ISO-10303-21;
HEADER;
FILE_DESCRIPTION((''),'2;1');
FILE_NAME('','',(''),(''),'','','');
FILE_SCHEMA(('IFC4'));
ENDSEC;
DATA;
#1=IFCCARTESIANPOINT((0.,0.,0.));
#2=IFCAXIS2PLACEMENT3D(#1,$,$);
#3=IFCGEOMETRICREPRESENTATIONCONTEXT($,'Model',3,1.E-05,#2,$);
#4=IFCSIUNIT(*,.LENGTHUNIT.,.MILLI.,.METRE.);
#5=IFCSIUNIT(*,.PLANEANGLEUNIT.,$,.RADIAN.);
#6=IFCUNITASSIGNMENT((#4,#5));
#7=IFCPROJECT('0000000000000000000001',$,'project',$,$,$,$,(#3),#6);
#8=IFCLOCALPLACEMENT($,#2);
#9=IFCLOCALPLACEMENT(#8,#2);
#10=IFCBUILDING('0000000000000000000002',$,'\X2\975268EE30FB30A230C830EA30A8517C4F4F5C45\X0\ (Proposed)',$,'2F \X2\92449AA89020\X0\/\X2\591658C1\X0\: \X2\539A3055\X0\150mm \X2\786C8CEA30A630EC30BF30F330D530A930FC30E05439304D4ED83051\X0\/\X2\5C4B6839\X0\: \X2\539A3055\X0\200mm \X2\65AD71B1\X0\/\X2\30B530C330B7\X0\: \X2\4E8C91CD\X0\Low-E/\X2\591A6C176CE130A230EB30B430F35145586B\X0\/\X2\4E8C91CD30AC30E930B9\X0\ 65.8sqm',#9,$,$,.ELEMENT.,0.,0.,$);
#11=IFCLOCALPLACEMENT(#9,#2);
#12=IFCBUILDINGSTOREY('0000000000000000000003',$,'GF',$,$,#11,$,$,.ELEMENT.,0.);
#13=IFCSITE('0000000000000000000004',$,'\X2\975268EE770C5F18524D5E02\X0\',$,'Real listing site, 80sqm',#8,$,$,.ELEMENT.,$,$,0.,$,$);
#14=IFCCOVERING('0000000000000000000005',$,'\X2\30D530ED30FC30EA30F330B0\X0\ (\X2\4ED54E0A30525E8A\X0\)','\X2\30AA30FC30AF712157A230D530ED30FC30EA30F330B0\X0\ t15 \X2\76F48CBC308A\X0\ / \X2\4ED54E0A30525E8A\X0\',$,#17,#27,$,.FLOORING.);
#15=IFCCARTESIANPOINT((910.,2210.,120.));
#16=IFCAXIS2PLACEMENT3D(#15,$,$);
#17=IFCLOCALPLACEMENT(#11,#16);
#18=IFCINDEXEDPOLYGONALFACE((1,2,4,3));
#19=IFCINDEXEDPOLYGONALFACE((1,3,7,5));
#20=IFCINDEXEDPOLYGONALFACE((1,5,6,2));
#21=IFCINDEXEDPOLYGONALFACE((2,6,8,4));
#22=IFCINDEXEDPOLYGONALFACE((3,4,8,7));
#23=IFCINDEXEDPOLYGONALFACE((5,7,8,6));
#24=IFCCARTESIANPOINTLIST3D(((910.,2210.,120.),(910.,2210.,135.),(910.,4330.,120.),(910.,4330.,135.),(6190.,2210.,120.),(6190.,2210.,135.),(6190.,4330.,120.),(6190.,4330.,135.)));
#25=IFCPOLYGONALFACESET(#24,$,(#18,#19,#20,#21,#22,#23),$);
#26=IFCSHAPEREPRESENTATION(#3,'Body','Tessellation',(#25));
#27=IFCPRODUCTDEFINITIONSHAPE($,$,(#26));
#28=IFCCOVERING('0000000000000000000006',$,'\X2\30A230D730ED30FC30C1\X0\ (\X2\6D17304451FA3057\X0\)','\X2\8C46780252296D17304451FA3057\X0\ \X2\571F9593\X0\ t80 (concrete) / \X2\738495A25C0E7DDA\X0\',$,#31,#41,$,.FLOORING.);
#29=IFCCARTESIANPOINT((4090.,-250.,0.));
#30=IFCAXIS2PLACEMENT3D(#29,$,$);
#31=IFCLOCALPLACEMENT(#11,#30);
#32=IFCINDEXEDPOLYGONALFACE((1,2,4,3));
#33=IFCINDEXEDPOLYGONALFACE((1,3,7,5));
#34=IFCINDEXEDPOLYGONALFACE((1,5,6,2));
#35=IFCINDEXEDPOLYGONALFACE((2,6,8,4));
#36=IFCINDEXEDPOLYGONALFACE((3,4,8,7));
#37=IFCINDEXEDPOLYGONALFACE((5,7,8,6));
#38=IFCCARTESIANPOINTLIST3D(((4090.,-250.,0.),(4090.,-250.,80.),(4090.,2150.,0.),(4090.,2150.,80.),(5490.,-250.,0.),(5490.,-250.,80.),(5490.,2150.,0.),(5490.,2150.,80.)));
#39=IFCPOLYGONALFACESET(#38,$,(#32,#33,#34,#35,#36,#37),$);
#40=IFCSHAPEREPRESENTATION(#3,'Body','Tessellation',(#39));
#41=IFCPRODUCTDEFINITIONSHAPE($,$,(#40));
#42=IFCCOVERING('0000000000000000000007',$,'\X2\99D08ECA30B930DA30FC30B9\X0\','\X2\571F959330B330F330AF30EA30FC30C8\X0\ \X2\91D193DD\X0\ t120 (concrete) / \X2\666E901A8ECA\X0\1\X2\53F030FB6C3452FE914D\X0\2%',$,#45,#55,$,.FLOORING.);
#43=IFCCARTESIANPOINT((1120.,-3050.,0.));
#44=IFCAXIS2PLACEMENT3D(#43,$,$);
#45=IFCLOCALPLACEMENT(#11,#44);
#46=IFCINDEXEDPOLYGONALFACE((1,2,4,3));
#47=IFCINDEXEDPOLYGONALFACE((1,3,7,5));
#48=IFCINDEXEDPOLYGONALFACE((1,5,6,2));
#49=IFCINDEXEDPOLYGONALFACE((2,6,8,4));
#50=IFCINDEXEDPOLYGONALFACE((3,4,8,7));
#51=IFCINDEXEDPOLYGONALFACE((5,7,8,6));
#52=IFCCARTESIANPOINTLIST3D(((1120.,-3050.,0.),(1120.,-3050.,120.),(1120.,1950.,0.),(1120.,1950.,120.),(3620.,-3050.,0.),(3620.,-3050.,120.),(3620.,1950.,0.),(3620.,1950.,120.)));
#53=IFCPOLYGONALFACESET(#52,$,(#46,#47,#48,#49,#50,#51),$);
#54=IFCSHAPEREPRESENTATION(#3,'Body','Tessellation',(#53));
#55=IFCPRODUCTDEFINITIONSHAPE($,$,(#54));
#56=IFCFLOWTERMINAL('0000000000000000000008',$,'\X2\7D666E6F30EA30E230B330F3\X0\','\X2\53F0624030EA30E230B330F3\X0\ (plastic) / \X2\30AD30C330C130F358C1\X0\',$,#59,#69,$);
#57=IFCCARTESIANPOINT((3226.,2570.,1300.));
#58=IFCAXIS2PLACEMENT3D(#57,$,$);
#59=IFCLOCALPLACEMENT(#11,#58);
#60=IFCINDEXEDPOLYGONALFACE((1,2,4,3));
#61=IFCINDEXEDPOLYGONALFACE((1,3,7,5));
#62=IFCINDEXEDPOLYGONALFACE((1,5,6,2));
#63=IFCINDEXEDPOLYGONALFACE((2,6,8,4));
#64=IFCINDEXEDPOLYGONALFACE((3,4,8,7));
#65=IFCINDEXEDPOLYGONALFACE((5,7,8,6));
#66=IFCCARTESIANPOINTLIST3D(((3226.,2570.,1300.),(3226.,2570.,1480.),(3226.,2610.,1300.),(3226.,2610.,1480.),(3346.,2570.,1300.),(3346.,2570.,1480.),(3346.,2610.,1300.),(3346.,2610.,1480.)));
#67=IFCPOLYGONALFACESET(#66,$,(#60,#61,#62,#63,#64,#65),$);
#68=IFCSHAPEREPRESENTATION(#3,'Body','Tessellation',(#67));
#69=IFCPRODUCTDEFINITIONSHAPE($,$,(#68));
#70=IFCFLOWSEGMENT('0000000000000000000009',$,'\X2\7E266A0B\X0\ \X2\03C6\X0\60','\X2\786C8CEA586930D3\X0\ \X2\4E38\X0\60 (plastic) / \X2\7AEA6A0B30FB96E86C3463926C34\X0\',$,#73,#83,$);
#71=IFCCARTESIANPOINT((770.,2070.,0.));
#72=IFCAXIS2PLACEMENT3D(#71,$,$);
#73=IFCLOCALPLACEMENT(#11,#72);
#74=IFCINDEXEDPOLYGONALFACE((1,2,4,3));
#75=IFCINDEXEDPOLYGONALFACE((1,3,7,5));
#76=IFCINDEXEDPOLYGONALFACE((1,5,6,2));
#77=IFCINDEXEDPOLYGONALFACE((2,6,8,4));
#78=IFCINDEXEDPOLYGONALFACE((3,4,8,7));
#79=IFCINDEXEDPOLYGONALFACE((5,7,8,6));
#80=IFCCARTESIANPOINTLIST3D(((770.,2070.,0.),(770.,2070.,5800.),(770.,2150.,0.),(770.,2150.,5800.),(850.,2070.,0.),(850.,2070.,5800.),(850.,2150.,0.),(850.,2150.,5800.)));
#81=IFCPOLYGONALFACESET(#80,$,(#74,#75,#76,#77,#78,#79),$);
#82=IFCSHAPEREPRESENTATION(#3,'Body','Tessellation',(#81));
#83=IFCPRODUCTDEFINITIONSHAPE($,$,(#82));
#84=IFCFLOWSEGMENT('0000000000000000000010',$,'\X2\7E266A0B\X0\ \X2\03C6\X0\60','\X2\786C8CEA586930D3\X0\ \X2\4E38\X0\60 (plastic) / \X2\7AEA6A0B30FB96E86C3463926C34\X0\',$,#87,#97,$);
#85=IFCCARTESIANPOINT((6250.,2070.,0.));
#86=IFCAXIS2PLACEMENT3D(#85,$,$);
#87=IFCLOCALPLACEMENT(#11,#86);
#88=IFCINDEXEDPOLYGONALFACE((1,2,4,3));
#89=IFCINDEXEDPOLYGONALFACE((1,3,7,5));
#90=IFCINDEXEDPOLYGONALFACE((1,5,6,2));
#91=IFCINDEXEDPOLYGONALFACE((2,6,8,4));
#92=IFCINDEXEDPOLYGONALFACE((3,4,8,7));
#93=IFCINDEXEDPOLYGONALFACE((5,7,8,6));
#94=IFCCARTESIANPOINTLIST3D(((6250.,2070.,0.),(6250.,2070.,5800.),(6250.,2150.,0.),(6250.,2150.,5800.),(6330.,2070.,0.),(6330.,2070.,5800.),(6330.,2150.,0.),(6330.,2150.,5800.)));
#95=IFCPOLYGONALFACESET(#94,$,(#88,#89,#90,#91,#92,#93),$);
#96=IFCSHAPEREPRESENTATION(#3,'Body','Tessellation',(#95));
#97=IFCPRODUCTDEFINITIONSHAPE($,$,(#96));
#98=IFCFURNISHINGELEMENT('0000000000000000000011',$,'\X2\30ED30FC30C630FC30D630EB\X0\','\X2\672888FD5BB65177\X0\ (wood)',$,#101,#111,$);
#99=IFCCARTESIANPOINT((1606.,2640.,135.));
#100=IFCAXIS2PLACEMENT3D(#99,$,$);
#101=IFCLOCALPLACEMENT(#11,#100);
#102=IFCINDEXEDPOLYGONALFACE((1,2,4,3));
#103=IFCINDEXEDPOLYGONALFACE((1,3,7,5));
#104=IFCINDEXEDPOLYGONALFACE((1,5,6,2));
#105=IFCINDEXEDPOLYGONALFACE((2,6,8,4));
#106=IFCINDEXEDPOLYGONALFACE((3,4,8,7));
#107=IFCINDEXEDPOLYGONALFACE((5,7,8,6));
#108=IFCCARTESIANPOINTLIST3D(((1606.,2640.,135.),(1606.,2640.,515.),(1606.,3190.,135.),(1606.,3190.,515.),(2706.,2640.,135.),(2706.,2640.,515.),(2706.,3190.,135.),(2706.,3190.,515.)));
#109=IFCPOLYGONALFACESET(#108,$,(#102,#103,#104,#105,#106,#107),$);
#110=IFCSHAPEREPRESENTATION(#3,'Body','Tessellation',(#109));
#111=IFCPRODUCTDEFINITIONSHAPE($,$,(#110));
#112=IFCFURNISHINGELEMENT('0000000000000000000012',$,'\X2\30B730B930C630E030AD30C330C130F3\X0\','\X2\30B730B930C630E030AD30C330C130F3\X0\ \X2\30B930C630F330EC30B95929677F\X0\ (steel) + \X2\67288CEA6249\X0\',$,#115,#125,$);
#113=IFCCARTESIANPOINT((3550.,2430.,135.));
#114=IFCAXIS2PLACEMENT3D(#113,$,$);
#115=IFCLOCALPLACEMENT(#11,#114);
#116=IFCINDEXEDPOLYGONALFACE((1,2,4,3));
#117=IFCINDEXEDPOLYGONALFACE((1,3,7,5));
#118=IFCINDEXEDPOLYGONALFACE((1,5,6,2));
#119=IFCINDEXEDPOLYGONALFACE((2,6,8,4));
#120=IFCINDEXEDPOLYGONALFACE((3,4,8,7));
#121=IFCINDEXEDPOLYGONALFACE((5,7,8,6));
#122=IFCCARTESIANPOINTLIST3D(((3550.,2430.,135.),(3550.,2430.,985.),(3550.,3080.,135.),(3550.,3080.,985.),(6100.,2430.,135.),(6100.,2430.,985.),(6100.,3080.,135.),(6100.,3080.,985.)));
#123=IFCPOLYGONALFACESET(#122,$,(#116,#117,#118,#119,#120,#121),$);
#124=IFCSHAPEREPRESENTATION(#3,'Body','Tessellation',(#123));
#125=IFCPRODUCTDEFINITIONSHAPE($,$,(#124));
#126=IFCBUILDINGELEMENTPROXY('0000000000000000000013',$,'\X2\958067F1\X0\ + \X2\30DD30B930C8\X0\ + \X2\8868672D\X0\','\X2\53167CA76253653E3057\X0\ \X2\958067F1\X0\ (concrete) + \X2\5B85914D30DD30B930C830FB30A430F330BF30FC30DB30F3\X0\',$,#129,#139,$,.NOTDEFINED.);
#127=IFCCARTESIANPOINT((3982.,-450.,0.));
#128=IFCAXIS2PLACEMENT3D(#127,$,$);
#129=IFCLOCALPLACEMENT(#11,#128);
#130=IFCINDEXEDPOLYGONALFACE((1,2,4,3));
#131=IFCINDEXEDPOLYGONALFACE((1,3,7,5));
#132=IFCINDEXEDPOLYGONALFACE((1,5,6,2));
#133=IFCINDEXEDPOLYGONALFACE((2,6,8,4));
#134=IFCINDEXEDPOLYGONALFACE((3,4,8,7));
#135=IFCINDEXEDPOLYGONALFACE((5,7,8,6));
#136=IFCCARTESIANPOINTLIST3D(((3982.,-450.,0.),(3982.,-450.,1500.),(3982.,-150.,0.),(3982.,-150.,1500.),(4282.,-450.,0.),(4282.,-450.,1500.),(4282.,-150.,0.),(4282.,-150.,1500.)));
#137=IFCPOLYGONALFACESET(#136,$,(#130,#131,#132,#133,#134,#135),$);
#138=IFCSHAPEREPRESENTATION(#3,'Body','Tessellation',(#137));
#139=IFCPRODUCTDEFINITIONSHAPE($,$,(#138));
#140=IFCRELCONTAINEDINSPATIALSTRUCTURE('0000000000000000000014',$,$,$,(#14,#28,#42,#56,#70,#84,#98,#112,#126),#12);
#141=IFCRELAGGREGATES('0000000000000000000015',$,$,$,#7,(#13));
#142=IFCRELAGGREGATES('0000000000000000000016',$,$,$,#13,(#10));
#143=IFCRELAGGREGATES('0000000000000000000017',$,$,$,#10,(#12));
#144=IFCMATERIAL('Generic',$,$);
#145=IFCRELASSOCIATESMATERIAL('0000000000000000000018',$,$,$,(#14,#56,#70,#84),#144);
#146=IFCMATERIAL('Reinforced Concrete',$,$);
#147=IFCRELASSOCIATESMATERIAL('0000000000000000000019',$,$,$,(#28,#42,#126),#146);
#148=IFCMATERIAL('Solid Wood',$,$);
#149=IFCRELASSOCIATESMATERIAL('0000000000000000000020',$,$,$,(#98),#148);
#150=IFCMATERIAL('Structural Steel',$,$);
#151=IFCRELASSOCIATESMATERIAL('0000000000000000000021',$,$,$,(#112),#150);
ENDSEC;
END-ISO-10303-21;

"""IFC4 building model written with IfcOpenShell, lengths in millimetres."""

from ifc_helpers import new_model, si_unit, frame, frame_2d, origin, place, context, project, spatial, rectangle, extrude, material, element, save


model = new_model("IFC4")

# Units and contexts
model_context = context("Model", 3, precision=1e-05, world=origin())
ifc_project = project(units=[si_unit("LENGTHUNIT", "METRE", prefix="MILLI"), si_unit("PLANEANGLEUNIT", "RADIAN")], contexts=[model_context])

# Site, building, storey
site_placement = place(None, origin())
site = spatial("IfcSite", under=ifc_project, at=site_placement, Name="青森県弘前市", ObjectType="Real listing site, 80sqm", CompositionType="ELEMENT", RefElevation=0.0)
building_placement = place(site_placement, origin())
building = spatial("IfcBuilding", under=site, at=building_placement, Name="青森・アトリエ兼住居 (Proposed)", ObjectType="2F 鉄骨造/外壁: 厚さ150mm 硬質ウレタンフォーム吹き付け/屋根: 厚さ200mm 断熱/サッシ: 二重Low-E/多気泡アルゴン充填/二重ガラス 65.8sqm", CompositionType="ELEMENT", ElevationOfRefHeight=0.0, ElevationOfTerrain=0.0)
storey_placement = place(building_placement, origin())
storey = spatial("IfcBuildingStorey", under=building, at=storey_placement, Name="GF", CompositionType="ELEMENT", Elevation=0.0)

# Shared definitions
ifc_material_1 = material(Name="Solid Wood")

# Shared definitions
ifc_material_2 = material(Name="Reinforced Concrete")

# Coverings
ifc_material_3 = material(Name="Generic")
covering_1_placement = place(storey_placement, frame((910.0, 2210.0, 120.0)))
element("IfcCovering", 1, at=covering_1_placement, inside=storey, material=ifc_material_3, Name="フローリング (仕上げ床)", Description="オーク無垢フローリング t15 直貼り / 仕上げ床", PredefinedType="FLOORING", context=model_context, shape_type="SweptSolid", body=[
    extrude(rectangle(XDim=5280.0, YDim=2120.0, at=frame_2d((2640.0, 1060.0))), frame((910.0, 2210.0, 120.0)), (0.0, 0.0, 1.0), 15.0),
])
covering_2_placement = place(storey_placement, frame((4090.0, -250.0, 0.0)))
element("IfcCovering", 2, at=covering_2_placement, inside=storey, material=ifc_material_2, Name="アプローチ (洗い出し)", Description="豆砂利洗い出し 土間 t80 (concrete) / 玄関導線", PredefinedType="FLOORING", context=model_context, shape_type="SweptSolid", body=[
    extrude(rectangle(XDim=1400.0, YDim=2400.0, at=frame_2d((700.0, 1200.0))), frame((4090.0, -250.0, 0.0)), (0.0, 0.0, 1.0), 80.0),
])
covering_3_placement = place(storey_placement, frame((1120.0, -3050.0, 0.0)))
element("IfcCovering", 3, at=covering_3_placement, inside=storey, material=ifc_material_2, Name="駐車スペース", Description="土間コンクリート 金鏝 t120 (concrete) / 普通車1台・水勾配2%", PredefinedType="FLOORING", context=model_context, shape_type="SweptSolid", body=[
    extrude(rectangle(XDim=2500.0, YDim=5000.0, at=frame_2d((1250.0, 2500.0))), frame((1120.0, -3050.0, 0.0)), (0.0, 0.0, 1.0), 120.0),
])

# Flow terminal
flow_terminal_placement = place(storey_placement, frame((3226.0, 2570.0, 1300.0)))
element("IfcFlowTerminal", 4, at=flow_terminal_placement, inside=storey, material=ifc_material_3, Name="給湯リモコン", Description="台所リモコン (plastic) / キッチン壁", context=model_context, shape_type="SweptSolid", body=[
    extrude(rectangle(XDim=120.0, YDim=40.0, at=frame_2d((60.0, 20.0))), frame((3226.0, 2570.0, 1300.0)), (0.0, 0.0, 1.0), 180.0),
])

# Flow segments
flow_segment_1_placement = place(storey_placement, frame((770.0, 2070.0, 0.0)))
element("IfcFlowSegment", 5, at=flow_segment_1_placement, inside=storey, material=ifc_material_3, Name="縦樋 φ60", Description="硬質塩ビ 丸60 (plastic) / 竪樋・雨水排水", context=model_context, shape_type="SweptSolid", body=[
    extrude(rectangle(XDim=80.0, YDim=80.0, at=frame_2d((40.0, 40.0))), frame((770.0, 2070.0, 0.0)), (0.0, 0.0, 1.0), 5800.0),
])
flow_segment_2_placement = place(storey_placement, frame((6250.0, 2070.0, 0.0)))
element("IfcFlowSegment", 6, at=flow_segment_2_placement, inside=storey, material=ifc_material_3, Name="縦樋 φ60", Description="硬質塩ビ 丸60 (plastic) / 竪樋・雨水排水", context=model_context, shape_type="SweptSolid", body=[
    extrude(rectangle(XDim=80.0, YDim=80.0, at=frame_2d((40.0, 40.0))), frame((6250.0, 2070.0, 0.0)), (0.0, 0.0, 1.0), 5800.0),
])

# Furnishing elements
furnishing_1_placement = place(storey_placement, frame((1606.0, 2640.0, 135.0)))
element("IfcFurnishingElement", 7, at=furnishing_1_placement, inside=storey, material=ifc_material_1, Name="ローテーブル", Description="木製家具 (wood)", context=model_context, shape_type="SweptSolid", body=[
    extrude(rectangle(XDim=1100.0, YDim=550.0, at=frame_2d((550.0, 275.0))), frame((1606.0, 2640.0, 135.0)), (0.0, 0.0, 1.0), 380.0),
])
ifc_material_4 = material(Name="Structural Steel")
furnishing_2_placement = place(storey_placement, frame((3550.0, 2430.0, 135.0)))
element("IfcFurnishingElement", 8, at=furnishing_2_placement, inside=storey, material=ifc_material_4, Name="システムキッチン", Description="システムキッチン ステンレス天板 (steel) + 木質扉", context=model_context, shape_type="SweptSolid", body=[
    extrude(rectangle(XDim=2550.0, YDim=650.0, at=frame_2d((1275.0, 325.0))), frame((3550.0, 2430.0, 135.0)), (0.0, 0.0, 1.0), 850.0),
])

# Building element proxy
proxy_placement = place(storey_placement, frame((3982.0, -450.0, 0.0)))
element("IfcBuildingElementProxy", 9, at=proxy_placement, inside=storey, material=ifc_material_2, Name="門柱 + ポスト + 表札", Description="化粧打放し 門柱 (concrete) + 宅配ポスト・インターホン", PredefinedType="NOTDEFINED", context=model_context, shape_type="SweptSolid", body=[
    extrude(rectangle(XDim=300.0, YDim=300.0, at=frame_2d((150.0, 150.0))), frame((3982.0, -450.0, 0.0)), (0.0, 0.0, 1.0), 1500.0),
])

save(model, "model.ifc")
